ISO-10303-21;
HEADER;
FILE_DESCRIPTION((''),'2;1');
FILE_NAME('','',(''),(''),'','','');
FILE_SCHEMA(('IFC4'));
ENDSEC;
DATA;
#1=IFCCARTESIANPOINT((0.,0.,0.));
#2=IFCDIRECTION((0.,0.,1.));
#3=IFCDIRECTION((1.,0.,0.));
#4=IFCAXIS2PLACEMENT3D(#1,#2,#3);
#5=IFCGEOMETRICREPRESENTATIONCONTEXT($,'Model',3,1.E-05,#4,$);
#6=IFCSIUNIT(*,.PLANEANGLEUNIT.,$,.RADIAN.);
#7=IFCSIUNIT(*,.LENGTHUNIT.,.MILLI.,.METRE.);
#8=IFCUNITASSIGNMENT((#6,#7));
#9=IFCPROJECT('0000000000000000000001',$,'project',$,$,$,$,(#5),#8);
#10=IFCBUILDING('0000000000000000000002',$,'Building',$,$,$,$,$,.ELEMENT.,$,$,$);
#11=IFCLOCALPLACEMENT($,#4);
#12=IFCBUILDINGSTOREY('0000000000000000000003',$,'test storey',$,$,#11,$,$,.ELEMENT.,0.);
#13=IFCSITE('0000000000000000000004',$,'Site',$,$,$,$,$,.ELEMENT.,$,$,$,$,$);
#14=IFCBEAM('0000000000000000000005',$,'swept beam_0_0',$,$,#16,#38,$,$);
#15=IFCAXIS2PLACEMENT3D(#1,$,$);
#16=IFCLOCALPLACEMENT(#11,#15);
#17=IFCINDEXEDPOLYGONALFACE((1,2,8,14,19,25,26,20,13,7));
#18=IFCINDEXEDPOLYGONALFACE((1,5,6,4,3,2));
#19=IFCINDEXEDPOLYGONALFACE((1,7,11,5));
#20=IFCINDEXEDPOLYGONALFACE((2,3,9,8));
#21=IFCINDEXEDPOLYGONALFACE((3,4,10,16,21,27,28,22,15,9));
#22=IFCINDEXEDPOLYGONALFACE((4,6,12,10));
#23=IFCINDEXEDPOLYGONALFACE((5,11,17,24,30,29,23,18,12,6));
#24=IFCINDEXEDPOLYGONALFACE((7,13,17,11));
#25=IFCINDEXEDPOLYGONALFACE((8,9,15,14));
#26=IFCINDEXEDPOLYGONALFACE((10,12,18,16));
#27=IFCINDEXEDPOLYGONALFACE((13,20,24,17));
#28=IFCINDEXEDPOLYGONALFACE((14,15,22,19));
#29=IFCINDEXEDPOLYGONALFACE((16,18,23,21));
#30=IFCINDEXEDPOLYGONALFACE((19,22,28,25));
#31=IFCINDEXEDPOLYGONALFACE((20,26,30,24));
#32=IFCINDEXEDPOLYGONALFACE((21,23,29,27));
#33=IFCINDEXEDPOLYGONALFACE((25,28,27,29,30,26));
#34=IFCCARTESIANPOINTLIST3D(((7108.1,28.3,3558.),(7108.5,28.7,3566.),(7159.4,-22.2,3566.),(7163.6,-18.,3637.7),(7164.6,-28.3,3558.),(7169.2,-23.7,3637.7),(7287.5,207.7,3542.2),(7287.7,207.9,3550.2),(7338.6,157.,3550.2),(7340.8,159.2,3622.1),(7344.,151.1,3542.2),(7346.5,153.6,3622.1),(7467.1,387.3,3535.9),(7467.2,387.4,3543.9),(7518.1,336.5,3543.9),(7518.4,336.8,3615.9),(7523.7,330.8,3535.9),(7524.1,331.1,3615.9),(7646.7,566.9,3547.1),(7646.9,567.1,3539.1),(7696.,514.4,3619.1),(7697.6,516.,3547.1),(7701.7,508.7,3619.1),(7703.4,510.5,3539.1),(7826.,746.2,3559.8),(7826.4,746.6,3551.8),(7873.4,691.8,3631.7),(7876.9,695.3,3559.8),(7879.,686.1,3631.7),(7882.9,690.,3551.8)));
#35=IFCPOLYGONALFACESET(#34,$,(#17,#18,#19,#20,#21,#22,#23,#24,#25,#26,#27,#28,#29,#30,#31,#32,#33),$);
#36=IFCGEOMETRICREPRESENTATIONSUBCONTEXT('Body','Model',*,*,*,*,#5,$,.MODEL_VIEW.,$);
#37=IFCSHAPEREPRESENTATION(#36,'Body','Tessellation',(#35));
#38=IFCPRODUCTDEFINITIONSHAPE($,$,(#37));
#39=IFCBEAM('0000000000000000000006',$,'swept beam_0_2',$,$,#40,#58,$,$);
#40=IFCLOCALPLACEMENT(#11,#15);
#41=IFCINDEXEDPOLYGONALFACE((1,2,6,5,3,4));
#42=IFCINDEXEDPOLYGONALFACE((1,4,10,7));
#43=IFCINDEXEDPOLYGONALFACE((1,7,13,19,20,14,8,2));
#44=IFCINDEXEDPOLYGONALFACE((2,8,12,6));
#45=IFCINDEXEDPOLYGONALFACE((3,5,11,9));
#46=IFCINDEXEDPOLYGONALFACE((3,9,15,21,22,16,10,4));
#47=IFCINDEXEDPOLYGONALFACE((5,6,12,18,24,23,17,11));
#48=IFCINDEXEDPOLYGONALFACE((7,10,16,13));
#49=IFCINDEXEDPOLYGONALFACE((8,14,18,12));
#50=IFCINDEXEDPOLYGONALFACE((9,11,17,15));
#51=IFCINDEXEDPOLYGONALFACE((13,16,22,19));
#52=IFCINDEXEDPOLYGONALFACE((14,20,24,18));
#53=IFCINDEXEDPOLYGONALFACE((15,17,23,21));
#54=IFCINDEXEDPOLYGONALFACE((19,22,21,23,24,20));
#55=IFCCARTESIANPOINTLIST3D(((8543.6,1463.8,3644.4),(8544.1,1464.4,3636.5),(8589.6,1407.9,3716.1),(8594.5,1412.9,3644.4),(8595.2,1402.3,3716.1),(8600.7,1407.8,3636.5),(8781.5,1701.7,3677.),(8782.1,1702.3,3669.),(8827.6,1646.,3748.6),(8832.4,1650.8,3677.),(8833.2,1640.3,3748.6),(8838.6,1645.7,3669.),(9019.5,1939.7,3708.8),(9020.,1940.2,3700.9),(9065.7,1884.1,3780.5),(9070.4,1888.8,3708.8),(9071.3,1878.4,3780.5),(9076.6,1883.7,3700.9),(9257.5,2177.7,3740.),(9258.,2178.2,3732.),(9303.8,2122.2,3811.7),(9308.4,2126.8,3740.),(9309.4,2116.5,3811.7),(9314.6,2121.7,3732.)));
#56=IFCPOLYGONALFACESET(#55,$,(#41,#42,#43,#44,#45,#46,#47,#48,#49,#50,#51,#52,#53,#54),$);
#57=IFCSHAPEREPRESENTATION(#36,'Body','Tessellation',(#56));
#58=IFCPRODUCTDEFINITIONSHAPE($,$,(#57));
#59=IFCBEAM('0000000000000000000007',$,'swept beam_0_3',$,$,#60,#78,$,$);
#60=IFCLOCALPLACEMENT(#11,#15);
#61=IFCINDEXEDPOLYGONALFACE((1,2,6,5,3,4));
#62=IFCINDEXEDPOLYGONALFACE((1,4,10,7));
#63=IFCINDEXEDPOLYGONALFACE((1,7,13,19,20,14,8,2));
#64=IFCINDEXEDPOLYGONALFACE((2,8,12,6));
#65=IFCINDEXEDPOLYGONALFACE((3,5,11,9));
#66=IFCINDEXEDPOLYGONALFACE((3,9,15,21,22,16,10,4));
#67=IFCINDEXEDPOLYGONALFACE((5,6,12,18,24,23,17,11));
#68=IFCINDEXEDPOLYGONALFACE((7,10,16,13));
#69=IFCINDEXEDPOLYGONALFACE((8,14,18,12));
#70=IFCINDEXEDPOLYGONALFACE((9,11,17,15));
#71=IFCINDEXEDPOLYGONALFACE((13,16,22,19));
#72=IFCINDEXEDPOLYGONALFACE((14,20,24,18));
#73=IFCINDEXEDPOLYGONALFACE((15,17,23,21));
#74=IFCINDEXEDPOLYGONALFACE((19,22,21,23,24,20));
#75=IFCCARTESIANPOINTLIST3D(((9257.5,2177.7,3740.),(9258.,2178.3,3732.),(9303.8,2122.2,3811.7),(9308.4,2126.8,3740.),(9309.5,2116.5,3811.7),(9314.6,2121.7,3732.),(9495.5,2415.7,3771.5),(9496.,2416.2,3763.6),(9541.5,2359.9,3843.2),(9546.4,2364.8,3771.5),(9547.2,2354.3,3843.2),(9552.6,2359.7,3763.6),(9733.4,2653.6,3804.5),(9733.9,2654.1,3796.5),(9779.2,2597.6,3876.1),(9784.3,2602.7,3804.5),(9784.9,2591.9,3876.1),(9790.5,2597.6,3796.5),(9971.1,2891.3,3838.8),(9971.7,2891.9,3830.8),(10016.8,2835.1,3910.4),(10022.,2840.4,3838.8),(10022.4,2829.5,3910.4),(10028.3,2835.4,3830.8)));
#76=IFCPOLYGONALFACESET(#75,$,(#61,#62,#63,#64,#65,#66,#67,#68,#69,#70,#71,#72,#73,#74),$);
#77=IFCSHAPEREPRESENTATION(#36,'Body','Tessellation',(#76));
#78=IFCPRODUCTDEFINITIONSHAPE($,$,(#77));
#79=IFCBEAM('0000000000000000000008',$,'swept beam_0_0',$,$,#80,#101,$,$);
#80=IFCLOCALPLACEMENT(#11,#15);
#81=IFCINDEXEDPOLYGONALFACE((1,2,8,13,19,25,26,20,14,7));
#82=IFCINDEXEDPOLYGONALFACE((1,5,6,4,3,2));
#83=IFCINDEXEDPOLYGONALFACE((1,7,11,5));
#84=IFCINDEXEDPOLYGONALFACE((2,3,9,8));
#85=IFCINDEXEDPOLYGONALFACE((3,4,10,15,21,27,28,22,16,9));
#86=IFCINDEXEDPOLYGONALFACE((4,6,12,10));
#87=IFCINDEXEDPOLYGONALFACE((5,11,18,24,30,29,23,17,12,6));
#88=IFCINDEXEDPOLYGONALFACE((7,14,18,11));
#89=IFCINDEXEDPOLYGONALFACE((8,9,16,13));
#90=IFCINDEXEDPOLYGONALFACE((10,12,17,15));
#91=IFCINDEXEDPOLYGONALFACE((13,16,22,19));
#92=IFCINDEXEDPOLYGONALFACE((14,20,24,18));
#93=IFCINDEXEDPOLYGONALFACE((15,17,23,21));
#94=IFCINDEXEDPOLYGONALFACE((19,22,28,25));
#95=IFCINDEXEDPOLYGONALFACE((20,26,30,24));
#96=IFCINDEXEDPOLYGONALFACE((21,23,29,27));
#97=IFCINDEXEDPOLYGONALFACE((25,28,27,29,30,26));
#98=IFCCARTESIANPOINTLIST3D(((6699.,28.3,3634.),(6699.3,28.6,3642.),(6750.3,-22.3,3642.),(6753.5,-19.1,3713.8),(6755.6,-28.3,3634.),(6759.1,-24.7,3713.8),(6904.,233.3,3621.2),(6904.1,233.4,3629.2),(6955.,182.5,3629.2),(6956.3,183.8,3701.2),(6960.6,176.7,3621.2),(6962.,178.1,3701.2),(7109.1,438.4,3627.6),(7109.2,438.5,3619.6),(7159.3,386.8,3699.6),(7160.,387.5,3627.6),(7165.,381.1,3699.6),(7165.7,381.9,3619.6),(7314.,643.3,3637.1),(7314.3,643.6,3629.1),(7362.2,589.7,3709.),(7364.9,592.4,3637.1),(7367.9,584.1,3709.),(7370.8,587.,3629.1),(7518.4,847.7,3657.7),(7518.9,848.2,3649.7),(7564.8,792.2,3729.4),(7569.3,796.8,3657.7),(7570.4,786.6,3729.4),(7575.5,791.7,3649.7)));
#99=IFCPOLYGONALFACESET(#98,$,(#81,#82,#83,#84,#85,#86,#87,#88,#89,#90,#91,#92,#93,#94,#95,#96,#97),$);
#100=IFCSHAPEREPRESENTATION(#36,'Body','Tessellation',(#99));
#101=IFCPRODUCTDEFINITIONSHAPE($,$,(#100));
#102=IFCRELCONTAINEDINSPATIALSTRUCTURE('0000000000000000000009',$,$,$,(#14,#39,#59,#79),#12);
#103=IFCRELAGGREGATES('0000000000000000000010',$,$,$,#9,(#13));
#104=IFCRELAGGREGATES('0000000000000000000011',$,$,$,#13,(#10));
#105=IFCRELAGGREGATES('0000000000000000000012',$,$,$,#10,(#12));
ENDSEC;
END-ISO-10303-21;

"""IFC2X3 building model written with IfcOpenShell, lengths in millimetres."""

from ifc_helpers import new_model, entity, si_unit, origin_with_axes, place, context, subcontext, project, spatial, element, save


model = new_model("IFC2X3")

# Units and contexts
model_context = context("Model", 3, precision=1e-05, world=origin_with_axes())
body_context = subcontext(model_context, "Body", "Model", "MODEL_VIEW")
ifc_project = project(units=[si_unit("PLANEANGLEUNIT", "RADIAN"), si_unit("LENGTHUNIT", "METRE", prefix="MILLI")], contexts=[model_context])

# Site, building, storey
site = spatial("IfcSite", under=ifc_project, Name="Site", CompositionType="ELEMENT")
building = spatial("IfcBuilding", under=site, Name="Building", CompositionType="ELEMENT")
storey_placement = place(None, origin_with_axes())
storey = spatial("IfcBuildingStorey", under=building, at=storey_placement, Name="test storey", CompositionType="ELEMENT", Elevation=0.0)

# Beams
beam_1_placement = place(storey_placement, origin_with_axes())
element("IfcBeam", 1, at=beam_1_placement, inside=storey, Name="swept beam_0_0", context=body_context, shape_type="SweptSolid", body=[
    entity("IfcRevolvedAreaSolid", entity("IfcArbitraryClosedProfileDef", "AREA", None, entity("IfcPolyline", [entity("IfcCartesianPoint", [-80.0, 40.0]), entity("IfcCartesianPoint", [-80.0, 32.0]), entity("IfcCartesianPoint", [-8.0, 32.0]), entity("IfcCartesianPoint", [-8.0, -40.0]), entity("IfcCartesianPoint", [0.0, -40.0]), entity("IfcCartesianPoint", [0.0, 40.0]), entity("IfcCartesianPoint", [-80.0, 40.0])])), entity("IfcAxis2Placement3D", entity("IfcCartesianPoint", [7136.4, 0.0, 3558.0]), entity("IfcDirection", [-0.7048, -0.7048, 0.081]), entity("IfcDirection", [-0.0573, -0.0573, -0.9967])), entity("IfcAxis1Placement", entity("IfcCartesianPoint", [-6777.2, 0.0, 0.0]), entity("IfcDirection", [0.0, 1.0, 0.0])), 0.150032),
])
beam_2_placement = place(storey_placement, origin_with_axes())
element("IfcBeam", 2, at=beam_2_placement, inside=storey, Name="swept beam_0_2", context=body_context, shape_type="SweptSolid", body=[
    entity("IfcRevolvedAreaSolid", entity("IfcArbitraryClosedProfileDef", "AREA", None, entity("IfcPolyline", [entity("IfcCartesianPoint", [80.0, -40.0]), entity("IfcCartesianPoint", [80.0, -32.0]), entity("IfcCartesianPoint", [8.0, -32.0]), entity("IfcCartesianPoint", [8.0, 40.0]), entity("IfcCartesianPoint", [0.0, 40.0]), entity("IfcCartesianPoint", [0.0, -40.0]), entity("IfcCartesianPoint", [80.0, -40.0])])), entity("IfcAxis2Placement3D", entity("IfcCartesianPoint", [8572.4, 1436.1, 3636.5]), entity("IfcDirection", [-0.7038, -0.7038, -0.0972]), entity("IfcDirection", [-0.0687, -0.0687, 0.9953])), entity("IfcAxis1Placement", entity("IfcCartesianPoint", [-171350.7, 0.0, 0.0]), entity("IfcDirection", [0.0, 1.0, 0.0])), 0.005918),
])
beam_3_placement = place(storey_placement, origin_with_axes())
element("IfcBeam", 3, at=beam_3_placement, inside=storey, Name="swept beam_0_3", context=body_context, shape_type="SweptSolid", body=[
    entity("IfcRevolvedAreaSolid", entity("IfcArbitraryClosedProfileDef", "AREA", None, entity("IfcPolyline", [entity("IfcCartesianPoint", [-80.0, 40.0]), entity("IfcCartesianPoint", [-80.0, 32.0]), entity("IfcCartesianPoint", [-8.0, 32.0]), entity("IfcCartesianPoint", [-8.0, -40.0]), entity("IfcCartesianPoint", [0.0, -40.0]), entity("IfcCartesianPoint", [0.0, 40.0]), entity("IfcCartesianPoint", [-80.0, 40.0])])), entity("IfcAxis2Placement3D", entity("IfcCartesianPoint", [9286.3, 2150.0, 3732.0]), entity("IfcDirection", [-0.7042, -0.7042, -0.0913]), entity("IfcDirection", [0.0645, 0.0645, -0.9958])), entity("IfcAxis1Placement", entity("IfcCartesianPoint", [-82219.2, 0.0, 0.0]), entity("IfcDirection", [0.0, 1.0, 0.0])), 0.012334),
])
beam_4_placement = place(storey_placement, origin_with_axes())
element("IfcBeam", 4, at=beam_4_placement, inside=storey, Name="swept beam_0_0", context=body_context, shape_type="SweptSolid", body=[
    entity("IfcRevolvedAreaSolid", entity("IfcArbitraryClosedProfileDef", "AREA", None, entity("IfcPolyline", [entity("IfcCartesianPoint", [-80.0, 40.0]), entity("IfcCartesianPoint", [-80.0, 32.0]), entity("IfcCartesianPoint", [-8.0, 32.0]), entity("IfcCartesianPoint", [-8.0, -40.0]), entity("IfcCartesianPoint", [0.0, -40.0]), entity("IfcCartesianPoint", [0.0, 40.0]), entity("IfcCartesianPoint", [-80.0, 40.0])])), entity("IfcAxis2Placement3D", entity("IfcCartesianPoint", [6727.3, 0.0, 3634.0]), entity("IfcDirection", [-0.7057, -0.7057, 0.063]), entity("IfcDirection", [-0.0446, -0.0446, -0.998])), entity("IfcAxis1Placement", entity("IfcCartesianPoint", [-7578.3, 0.0, 0.0]), entity("IfcDirection", [0.0, 1.0, 0.0])), 0.153177),
])

save(model, "model.ifc")
